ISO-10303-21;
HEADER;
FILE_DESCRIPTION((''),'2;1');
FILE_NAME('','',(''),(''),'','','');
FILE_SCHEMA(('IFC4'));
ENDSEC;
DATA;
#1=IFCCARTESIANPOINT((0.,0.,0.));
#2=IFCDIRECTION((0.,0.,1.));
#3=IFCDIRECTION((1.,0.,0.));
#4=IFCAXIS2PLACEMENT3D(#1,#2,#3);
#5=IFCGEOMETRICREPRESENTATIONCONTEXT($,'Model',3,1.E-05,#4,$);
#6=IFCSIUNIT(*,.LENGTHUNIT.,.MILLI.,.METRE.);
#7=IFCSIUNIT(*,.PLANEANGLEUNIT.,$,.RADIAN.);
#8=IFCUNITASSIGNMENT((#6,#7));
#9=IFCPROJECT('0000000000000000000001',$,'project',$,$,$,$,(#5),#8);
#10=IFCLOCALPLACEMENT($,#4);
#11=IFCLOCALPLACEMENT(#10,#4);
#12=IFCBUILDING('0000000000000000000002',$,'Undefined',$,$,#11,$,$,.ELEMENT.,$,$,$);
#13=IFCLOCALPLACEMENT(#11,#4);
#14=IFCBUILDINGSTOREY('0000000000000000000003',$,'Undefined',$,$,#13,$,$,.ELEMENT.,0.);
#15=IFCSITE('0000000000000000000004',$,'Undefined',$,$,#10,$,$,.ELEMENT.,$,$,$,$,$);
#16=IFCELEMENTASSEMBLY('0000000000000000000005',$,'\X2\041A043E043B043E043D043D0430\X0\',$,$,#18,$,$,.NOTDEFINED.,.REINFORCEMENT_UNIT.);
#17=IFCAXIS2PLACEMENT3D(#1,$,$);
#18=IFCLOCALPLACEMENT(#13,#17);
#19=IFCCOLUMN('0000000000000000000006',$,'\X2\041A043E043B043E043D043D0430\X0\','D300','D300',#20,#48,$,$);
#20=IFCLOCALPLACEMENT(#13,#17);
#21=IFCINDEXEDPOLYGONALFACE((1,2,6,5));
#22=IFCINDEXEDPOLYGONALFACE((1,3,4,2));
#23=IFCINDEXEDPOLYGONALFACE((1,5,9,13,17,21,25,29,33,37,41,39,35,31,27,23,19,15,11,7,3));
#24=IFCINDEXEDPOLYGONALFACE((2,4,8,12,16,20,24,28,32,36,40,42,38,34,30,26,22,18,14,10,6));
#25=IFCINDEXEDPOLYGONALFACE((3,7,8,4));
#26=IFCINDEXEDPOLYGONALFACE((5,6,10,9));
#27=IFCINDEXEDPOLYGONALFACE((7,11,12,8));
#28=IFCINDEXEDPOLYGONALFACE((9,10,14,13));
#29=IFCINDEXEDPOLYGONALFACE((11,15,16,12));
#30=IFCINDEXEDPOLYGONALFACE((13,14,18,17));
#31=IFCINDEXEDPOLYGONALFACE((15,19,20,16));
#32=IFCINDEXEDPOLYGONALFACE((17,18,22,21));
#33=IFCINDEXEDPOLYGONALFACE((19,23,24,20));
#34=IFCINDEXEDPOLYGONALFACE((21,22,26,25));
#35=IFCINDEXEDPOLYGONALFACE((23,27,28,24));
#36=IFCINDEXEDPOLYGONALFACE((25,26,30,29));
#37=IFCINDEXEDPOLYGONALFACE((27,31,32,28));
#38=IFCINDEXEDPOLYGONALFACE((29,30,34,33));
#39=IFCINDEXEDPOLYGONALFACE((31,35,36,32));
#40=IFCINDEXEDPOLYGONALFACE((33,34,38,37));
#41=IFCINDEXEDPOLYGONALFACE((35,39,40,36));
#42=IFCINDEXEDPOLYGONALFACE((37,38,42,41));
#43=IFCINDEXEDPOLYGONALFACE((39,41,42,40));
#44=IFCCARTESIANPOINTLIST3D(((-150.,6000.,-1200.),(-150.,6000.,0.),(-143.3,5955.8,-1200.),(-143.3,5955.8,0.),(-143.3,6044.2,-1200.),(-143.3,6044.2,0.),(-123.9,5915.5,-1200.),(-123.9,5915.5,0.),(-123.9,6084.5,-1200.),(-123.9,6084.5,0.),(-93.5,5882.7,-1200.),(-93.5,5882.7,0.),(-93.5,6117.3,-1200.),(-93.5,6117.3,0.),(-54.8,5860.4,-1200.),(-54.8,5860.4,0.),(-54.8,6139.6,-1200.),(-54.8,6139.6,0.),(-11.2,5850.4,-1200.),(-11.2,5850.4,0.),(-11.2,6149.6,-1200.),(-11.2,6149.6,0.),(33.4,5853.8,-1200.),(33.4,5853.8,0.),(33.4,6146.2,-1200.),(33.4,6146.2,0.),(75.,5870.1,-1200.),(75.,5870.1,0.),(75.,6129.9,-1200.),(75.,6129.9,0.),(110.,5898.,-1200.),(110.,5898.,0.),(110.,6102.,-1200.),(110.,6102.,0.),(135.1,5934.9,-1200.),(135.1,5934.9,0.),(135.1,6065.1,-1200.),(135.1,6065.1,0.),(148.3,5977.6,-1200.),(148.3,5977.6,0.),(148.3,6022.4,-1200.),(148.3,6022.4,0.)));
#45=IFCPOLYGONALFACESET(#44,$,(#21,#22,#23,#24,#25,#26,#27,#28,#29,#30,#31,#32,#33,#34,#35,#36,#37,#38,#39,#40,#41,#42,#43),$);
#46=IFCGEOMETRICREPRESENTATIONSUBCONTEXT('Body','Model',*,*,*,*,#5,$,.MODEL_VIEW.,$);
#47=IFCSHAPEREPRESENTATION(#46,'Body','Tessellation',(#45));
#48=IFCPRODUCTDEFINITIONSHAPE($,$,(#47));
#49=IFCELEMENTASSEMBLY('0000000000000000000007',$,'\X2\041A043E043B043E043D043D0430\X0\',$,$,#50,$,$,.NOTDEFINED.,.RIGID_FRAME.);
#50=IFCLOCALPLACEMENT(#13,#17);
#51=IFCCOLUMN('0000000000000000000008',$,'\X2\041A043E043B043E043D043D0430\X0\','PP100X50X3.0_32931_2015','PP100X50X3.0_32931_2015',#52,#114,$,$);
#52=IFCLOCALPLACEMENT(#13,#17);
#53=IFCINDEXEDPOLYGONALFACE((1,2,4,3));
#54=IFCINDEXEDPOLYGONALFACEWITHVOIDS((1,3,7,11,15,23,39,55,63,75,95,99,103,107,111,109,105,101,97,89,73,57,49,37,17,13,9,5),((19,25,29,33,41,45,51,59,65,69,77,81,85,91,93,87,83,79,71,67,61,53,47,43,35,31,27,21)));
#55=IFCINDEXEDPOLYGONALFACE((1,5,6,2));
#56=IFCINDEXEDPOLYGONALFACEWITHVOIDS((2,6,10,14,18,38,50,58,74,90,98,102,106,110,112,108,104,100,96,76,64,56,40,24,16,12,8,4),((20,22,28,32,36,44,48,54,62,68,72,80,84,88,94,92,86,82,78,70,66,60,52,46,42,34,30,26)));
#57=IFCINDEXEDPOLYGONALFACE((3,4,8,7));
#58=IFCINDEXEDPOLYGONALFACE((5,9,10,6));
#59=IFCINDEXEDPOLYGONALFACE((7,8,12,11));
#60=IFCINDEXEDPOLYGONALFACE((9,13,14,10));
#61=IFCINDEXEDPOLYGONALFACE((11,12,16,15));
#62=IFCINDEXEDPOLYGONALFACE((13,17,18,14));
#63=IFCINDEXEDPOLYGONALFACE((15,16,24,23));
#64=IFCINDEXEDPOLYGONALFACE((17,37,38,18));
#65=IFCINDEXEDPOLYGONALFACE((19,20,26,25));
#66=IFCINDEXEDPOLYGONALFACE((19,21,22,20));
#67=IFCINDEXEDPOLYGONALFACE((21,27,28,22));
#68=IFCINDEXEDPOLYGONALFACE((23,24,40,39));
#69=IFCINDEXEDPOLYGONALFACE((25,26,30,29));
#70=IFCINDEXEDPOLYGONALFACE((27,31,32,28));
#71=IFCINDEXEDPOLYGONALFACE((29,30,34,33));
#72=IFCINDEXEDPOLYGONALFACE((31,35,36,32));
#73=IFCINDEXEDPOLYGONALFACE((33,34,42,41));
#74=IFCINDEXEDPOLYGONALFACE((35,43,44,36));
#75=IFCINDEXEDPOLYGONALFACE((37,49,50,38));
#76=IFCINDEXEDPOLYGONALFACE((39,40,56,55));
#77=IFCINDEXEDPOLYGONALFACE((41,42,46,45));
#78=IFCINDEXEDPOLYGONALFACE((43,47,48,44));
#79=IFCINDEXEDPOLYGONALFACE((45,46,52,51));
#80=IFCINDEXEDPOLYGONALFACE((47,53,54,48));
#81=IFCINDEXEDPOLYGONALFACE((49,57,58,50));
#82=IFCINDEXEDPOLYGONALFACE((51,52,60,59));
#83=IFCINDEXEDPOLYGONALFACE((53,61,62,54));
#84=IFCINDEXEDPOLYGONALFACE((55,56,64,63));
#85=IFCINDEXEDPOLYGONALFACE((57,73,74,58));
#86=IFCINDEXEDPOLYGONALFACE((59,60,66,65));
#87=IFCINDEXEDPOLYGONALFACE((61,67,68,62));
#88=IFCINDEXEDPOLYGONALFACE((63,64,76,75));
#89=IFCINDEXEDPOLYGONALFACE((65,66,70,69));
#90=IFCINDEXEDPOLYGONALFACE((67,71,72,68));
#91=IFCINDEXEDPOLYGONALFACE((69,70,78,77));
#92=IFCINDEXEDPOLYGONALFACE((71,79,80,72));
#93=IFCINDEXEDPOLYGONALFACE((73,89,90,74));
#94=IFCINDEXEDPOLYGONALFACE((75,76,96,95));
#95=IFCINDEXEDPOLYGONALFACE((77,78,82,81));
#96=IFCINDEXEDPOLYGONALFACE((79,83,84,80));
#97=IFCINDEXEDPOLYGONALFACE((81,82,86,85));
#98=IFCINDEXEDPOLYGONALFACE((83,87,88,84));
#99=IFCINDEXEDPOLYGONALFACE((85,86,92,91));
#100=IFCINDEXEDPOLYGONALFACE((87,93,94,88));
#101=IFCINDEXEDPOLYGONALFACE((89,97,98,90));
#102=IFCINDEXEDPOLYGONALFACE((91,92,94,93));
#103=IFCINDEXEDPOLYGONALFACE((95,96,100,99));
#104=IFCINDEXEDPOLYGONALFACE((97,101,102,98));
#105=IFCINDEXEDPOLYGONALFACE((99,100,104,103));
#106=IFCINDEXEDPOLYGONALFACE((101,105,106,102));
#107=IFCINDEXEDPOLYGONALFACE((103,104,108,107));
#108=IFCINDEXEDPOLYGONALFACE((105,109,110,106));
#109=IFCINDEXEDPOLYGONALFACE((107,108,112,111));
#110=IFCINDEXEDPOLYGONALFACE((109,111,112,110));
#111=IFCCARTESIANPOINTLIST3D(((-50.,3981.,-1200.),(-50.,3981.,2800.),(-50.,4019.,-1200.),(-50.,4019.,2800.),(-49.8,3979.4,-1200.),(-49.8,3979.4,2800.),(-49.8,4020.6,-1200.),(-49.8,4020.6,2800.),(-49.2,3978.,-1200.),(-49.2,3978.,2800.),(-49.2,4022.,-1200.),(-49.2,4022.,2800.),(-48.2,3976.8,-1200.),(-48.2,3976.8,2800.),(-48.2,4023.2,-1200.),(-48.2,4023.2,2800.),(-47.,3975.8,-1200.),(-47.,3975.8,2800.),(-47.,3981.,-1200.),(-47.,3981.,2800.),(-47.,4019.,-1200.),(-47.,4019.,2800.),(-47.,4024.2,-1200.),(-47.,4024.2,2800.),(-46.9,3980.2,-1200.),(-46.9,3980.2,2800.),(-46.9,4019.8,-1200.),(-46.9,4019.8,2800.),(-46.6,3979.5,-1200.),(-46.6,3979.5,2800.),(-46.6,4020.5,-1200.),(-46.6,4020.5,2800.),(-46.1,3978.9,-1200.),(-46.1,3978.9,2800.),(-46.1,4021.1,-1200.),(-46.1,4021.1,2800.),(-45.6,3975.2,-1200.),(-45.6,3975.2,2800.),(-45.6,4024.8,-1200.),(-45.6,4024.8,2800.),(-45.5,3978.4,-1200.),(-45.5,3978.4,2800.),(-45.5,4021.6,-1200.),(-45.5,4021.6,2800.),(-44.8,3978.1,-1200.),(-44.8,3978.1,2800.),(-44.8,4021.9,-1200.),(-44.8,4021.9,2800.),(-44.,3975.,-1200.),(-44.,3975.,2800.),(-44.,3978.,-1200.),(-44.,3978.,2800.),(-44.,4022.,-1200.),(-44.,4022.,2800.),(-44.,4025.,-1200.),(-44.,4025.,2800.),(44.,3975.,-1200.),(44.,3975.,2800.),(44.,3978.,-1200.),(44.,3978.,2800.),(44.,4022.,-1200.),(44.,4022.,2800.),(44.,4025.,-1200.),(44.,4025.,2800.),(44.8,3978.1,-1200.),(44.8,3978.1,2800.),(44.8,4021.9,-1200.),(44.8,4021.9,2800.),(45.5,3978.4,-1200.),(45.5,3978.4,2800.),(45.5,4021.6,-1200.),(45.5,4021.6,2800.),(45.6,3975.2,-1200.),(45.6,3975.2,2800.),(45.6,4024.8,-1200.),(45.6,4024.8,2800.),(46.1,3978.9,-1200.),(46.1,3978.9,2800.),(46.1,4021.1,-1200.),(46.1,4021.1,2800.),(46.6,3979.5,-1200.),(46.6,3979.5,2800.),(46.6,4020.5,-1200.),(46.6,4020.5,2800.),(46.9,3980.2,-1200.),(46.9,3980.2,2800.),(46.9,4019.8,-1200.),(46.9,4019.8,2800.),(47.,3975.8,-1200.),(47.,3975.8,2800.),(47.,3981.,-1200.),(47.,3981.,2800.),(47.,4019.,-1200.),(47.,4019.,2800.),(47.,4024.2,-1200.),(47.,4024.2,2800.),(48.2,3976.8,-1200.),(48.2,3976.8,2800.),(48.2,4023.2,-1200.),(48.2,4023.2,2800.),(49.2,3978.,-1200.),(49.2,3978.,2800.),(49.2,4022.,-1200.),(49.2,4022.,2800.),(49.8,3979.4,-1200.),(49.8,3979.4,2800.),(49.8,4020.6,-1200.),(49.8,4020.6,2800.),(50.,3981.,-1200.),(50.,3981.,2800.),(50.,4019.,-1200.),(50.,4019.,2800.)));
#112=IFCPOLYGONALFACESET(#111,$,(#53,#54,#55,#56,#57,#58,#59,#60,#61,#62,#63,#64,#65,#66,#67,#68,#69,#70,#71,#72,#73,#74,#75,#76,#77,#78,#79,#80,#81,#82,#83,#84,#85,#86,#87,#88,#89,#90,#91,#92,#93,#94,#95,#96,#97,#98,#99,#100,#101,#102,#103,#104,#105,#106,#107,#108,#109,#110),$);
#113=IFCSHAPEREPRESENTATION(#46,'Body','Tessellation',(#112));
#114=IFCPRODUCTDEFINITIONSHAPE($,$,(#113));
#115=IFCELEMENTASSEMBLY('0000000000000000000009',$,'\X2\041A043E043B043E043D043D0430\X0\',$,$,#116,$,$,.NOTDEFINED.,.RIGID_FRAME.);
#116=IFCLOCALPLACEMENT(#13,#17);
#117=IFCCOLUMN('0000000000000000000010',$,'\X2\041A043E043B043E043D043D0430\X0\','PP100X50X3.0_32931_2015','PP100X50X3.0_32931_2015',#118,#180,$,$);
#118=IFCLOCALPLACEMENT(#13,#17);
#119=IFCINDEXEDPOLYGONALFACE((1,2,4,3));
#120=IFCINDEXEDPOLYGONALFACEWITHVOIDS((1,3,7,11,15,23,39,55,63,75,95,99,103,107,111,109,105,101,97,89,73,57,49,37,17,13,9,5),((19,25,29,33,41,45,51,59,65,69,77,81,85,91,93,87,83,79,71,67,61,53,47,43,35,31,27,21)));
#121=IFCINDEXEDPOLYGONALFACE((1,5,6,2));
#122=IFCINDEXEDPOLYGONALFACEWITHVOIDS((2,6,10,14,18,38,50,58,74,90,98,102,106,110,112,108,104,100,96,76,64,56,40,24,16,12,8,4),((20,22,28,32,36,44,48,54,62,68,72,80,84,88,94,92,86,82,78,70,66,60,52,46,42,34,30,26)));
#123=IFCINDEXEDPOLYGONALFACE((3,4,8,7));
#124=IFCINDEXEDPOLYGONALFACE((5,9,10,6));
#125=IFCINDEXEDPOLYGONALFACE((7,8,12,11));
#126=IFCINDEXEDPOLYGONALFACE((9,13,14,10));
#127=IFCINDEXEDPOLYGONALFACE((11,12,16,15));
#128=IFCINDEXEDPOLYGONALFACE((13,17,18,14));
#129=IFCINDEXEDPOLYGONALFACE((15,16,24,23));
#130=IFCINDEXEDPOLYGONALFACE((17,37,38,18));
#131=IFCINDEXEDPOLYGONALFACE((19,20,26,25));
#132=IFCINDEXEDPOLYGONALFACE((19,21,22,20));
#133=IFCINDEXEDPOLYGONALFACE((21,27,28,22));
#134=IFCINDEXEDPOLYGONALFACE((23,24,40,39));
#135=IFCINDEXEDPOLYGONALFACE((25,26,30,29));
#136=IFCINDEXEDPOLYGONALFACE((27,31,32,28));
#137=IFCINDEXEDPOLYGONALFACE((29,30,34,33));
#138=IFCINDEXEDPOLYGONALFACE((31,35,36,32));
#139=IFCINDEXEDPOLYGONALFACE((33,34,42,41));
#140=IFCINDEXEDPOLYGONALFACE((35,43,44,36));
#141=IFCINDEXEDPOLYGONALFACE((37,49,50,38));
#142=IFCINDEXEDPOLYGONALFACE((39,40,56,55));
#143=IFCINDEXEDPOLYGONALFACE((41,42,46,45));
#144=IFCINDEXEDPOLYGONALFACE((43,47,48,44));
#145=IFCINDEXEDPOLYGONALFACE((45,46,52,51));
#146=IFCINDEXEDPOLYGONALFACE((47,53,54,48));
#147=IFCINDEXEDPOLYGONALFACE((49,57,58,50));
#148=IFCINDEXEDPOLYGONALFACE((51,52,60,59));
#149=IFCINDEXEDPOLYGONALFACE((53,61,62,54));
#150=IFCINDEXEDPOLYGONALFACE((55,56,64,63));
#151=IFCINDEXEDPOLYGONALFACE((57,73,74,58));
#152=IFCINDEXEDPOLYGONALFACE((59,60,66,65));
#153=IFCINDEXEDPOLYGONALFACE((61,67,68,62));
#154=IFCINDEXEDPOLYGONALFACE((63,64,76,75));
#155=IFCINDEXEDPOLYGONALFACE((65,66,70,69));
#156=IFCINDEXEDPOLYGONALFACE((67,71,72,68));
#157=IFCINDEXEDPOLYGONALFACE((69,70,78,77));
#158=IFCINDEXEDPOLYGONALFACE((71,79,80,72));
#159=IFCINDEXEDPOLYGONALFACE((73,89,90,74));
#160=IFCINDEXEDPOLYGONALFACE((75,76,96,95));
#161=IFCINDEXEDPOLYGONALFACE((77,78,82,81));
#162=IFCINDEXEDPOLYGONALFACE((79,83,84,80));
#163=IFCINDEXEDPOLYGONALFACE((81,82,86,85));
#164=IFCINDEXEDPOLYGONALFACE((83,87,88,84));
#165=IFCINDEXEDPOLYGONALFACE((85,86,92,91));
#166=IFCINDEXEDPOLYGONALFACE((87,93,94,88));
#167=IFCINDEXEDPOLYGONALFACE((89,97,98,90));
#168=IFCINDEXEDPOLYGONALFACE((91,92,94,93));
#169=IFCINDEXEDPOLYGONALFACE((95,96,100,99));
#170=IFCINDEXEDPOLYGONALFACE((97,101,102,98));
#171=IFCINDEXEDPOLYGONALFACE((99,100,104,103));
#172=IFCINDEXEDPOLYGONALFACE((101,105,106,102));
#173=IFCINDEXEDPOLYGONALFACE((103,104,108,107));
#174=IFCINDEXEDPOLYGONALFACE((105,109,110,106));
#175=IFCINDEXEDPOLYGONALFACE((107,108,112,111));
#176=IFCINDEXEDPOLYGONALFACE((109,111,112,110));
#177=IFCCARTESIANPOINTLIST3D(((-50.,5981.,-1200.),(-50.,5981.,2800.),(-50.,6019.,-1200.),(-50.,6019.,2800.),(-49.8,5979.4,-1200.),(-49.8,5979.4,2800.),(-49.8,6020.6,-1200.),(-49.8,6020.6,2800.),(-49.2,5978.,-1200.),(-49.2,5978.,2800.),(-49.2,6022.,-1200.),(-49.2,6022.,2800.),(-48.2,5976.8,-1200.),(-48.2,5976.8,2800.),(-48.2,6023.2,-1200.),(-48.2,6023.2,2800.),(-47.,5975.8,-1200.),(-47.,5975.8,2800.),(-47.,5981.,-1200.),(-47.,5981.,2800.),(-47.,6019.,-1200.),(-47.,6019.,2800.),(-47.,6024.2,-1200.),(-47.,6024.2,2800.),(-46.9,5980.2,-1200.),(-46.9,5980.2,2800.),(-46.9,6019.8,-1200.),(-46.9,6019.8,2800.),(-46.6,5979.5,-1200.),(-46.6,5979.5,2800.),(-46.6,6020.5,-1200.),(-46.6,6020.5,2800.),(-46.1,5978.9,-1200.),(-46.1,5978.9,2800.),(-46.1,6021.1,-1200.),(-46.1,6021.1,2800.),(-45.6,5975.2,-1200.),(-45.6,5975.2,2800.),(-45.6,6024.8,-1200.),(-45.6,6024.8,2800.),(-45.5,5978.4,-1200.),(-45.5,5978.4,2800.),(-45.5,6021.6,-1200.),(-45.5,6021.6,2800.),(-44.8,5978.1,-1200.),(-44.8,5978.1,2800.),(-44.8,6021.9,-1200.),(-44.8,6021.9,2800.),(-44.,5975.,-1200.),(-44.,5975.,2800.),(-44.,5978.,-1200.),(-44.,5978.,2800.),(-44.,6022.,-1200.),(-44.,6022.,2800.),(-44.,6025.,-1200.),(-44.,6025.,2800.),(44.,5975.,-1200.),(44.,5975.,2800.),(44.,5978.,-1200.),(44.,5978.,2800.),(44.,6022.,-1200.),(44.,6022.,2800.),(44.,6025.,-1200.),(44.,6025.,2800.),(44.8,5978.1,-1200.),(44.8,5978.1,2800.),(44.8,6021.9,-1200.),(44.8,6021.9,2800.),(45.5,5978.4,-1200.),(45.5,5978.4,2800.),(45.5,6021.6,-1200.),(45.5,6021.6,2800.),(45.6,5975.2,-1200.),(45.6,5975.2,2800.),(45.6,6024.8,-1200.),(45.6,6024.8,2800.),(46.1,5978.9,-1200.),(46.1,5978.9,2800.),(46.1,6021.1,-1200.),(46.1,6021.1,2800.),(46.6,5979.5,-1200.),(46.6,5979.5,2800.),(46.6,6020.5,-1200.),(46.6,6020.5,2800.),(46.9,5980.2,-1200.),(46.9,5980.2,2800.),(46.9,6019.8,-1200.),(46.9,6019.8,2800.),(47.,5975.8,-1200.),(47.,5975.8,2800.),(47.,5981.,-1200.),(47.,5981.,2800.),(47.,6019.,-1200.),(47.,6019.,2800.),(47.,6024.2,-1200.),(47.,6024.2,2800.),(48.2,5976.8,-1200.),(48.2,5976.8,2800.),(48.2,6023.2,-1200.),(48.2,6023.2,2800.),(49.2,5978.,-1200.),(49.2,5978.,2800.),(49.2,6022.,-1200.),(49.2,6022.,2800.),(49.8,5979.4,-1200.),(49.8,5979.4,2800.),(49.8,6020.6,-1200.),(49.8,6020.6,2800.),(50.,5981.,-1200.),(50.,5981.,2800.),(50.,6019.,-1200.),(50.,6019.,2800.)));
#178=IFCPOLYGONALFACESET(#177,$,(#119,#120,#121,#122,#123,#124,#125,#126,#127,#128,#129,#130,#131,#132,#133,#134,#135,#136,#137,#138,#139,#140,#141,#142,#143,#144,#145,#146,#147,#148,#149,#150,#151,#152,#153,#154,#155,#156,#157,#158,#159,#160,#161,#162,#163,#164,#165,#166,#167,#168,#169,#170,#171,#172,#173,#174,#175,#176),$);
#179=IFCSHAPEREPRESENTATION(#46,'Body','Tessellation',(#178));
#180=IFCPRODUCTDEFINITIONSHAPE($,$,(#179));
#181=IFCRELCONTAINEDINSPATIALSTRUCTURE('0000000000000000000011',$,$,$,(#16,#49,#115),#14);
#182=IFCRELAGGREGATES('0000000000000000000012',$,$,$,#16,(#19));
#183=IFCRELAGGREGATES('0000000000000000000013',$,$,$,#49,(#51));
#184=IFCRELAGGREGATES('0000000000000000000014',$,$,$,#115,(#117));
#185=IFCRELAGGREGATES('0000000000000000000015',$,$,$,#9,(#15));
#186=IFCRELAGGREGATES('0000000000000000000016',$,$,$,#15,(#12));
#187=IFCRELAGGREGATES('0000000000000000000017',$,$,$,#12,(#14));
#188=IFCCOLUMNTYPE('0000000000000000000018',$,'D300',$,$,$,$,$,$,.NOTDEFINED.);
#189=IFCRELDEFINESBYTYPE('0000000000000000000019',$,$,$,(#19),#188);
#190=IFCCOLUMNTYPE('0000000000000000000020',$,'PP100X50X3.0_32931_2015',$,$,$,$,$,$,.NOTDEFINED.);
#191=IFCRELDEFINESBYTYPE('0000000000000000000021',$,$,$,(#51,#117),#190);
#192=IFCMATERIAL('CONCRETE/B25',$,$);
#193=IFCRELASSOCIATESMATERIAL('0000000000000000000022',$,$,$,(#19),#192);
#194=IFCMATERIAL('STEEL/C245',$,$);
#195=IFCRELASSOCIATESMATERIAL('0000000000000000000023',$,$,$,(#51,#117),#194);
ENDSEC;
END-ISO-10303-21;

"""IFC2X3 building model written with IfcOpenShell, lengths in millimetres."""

from ifc_helpers import new_model, si_unit, frame, origin_with_axes, origin_2d_with_axis, place, context, subcontext, project, spatial, hollow_rectangle, circle, extrude, material, type_object, element, aggregate, save


model = new_model("IFC2X3")

# Units and contexts
model_context = context("Model", 3, precision=1e-05, world=origin_with_axes())
body_context = subcontext(model_context, "Body", "Model", "MODEL_VIEW")
ifc_project = project(units=[si_unit("LENGTHUNIT", "METRE", prefix="MILLI"), si_unit("PLANEANGLEUNIT", "RADIAN")], contexts=[model_context])

# Site, building, storey
site_placement = place(None, origin_with_axes())
site = spatial("IfcSite", under=ifc_project, at=site_placement, Name="Undefined", CompositionType="ELEMENT")
building_placement = place(site_placement, origin_with_axes())
building = spatial("IfcBuilding", under=site, at=building_placement, Name="Undefined", CompositionType="ELEMENT")
storey_placement = place(building_placement, origin_with_axes())
storey = spatial("IfcBuildingStorey", under=building, at=storey_placement, Name="Undefined", CompositionType="ELEMENT", Elevation=0.0)

# Element assemblies, columns
assembly_1_placement = place(storey_placement, origin_with_axes())
assembly_1 = element("IfcElementAssembly", 1, at=assembly_1_placement, inside=storey, Name="Колонна", AssemblyPlace="NOTDEFINED", PredefinedType="REINFORCEMENT_UNIT")
ifc_material_1 = material(Name="CONCRETE/B25")
column_type_1 = type_object("IfcColumnType", Name="D300", PredefinedType="NOTDEFINED")
column_1_placement = place(assembly_1_placement, frame((0.0, 6000.0, -1200.0), z_axis=(0.0, 0.0, 1.0), x_axis=(0.0, 1.0, 0.0)))
column_1 = element("IfcColumn", 2, at=column_1_placement, type_object=column_type_1, material=ifc_material_1, Name="Колонна", Description="D300", ObjectType="D300", context=body_context, shape_type="SweptSolid", body=[
    extrude(circle(Radius=150.0, at=origin_2d_with_axis()), frame((0.0, 0.0, 1200.0), z_axis=(0.0, 0.0, -1.0), x_axis=(0.0, 1.0, 0.0)), (0.0, 0.0, 1.0), 1200.0),
])
aggregate(assembly_1, [column_1])
assembly_2_placement = place(storey_placement, origin_with_axes())
assembly_2 = element("IfcElementAssembly", 3, at=assembly_2_placement, inside=storey, Name="Колонна", AssemblyPlace="NOTDEFINED", PredefinedType="RIGID_FRAME")
ifc_material_2 = material(Name="STEEL/C245")
column_type_2 = type_object("IfcColumnType", Name="PP100X50X3.0_32931_2015", PredefinedType="NOTDEFINED")
column_2_placement = place(assembly_2_placement, frame((0.0, 4000.0, -1200.0), z_axis=(0.0, 0.0, 1.0), x_axis=(-1.0, 0.0, 0.0)))
column_2 = element("IfcColumn", 4, at=column_2_placement, type_object=column_type_2, material=ifc_material_2, Name="Колонна", Description="PP100X50X3.0_32931_2015", ObjectType="PP100X50X3.0_32931_2015", context=body_context, shape_type="SweptSolid", body=[
    extrude(hollow_rectangle(XDim=50.0, YDim=100.0, WallThickness=3.0, InnerFilletRadius=3.0, OuterFilletRadius=6.0, at=origin_2d_with_axis()), frame((0.0, 0.0, 4000.0), z_axis=(0.0, 0.0, -1.0), x_axis=(0.0, 1.0, 0.0)), (0.0, 0.0, 1.0), 4000.0),
])
aggregate(assembly_2, [column_2])
assembly_3_placement = place(storey_placement, origin_with_axes())
assembly_3 = element("IfcElementAssembly", 5, at=assembly_3_placement, inside=storey, Name="Колонна", AssemblyPlace="NOTDEFINED", PredefinedType="RIGID_FRAME")
column_3_placement = place(assembly_3_placement, frame((0.0, 6000.0, -1200.0), z_axis=(0.0, 0.0, 1.0), x_axis=(-1.0, 0.0, 0.0)))
column_3 = element("IfcColumn", 6, at=column_3_placement, type_object=column_type_2, material=ifc_material_2, Name="Колонна", Description="PP100X50X3.0_32931_2015", ObjectType="PP100X50X3.0_32931_2015", context=body_context, shape_type="SweptSolid", body=[
    extrude(hollow_rectangle(XDim=50.0, YDim=100.0, WallThickness=3.0, InnerFilletRadius=3.0, OuterFilletRadius=6.0, at=origin_2d_with_axis()), frame((0.0, 0.0, 4000.0), z_axis=(0.0, 0.0, -1.0), x_axis=(0.0, 1.0, 0.0)), (0.0, 0.0, 1.0), 4000.0),
])
aggregate(assembly_3, [column_3])

save(model, "model.ifc")
